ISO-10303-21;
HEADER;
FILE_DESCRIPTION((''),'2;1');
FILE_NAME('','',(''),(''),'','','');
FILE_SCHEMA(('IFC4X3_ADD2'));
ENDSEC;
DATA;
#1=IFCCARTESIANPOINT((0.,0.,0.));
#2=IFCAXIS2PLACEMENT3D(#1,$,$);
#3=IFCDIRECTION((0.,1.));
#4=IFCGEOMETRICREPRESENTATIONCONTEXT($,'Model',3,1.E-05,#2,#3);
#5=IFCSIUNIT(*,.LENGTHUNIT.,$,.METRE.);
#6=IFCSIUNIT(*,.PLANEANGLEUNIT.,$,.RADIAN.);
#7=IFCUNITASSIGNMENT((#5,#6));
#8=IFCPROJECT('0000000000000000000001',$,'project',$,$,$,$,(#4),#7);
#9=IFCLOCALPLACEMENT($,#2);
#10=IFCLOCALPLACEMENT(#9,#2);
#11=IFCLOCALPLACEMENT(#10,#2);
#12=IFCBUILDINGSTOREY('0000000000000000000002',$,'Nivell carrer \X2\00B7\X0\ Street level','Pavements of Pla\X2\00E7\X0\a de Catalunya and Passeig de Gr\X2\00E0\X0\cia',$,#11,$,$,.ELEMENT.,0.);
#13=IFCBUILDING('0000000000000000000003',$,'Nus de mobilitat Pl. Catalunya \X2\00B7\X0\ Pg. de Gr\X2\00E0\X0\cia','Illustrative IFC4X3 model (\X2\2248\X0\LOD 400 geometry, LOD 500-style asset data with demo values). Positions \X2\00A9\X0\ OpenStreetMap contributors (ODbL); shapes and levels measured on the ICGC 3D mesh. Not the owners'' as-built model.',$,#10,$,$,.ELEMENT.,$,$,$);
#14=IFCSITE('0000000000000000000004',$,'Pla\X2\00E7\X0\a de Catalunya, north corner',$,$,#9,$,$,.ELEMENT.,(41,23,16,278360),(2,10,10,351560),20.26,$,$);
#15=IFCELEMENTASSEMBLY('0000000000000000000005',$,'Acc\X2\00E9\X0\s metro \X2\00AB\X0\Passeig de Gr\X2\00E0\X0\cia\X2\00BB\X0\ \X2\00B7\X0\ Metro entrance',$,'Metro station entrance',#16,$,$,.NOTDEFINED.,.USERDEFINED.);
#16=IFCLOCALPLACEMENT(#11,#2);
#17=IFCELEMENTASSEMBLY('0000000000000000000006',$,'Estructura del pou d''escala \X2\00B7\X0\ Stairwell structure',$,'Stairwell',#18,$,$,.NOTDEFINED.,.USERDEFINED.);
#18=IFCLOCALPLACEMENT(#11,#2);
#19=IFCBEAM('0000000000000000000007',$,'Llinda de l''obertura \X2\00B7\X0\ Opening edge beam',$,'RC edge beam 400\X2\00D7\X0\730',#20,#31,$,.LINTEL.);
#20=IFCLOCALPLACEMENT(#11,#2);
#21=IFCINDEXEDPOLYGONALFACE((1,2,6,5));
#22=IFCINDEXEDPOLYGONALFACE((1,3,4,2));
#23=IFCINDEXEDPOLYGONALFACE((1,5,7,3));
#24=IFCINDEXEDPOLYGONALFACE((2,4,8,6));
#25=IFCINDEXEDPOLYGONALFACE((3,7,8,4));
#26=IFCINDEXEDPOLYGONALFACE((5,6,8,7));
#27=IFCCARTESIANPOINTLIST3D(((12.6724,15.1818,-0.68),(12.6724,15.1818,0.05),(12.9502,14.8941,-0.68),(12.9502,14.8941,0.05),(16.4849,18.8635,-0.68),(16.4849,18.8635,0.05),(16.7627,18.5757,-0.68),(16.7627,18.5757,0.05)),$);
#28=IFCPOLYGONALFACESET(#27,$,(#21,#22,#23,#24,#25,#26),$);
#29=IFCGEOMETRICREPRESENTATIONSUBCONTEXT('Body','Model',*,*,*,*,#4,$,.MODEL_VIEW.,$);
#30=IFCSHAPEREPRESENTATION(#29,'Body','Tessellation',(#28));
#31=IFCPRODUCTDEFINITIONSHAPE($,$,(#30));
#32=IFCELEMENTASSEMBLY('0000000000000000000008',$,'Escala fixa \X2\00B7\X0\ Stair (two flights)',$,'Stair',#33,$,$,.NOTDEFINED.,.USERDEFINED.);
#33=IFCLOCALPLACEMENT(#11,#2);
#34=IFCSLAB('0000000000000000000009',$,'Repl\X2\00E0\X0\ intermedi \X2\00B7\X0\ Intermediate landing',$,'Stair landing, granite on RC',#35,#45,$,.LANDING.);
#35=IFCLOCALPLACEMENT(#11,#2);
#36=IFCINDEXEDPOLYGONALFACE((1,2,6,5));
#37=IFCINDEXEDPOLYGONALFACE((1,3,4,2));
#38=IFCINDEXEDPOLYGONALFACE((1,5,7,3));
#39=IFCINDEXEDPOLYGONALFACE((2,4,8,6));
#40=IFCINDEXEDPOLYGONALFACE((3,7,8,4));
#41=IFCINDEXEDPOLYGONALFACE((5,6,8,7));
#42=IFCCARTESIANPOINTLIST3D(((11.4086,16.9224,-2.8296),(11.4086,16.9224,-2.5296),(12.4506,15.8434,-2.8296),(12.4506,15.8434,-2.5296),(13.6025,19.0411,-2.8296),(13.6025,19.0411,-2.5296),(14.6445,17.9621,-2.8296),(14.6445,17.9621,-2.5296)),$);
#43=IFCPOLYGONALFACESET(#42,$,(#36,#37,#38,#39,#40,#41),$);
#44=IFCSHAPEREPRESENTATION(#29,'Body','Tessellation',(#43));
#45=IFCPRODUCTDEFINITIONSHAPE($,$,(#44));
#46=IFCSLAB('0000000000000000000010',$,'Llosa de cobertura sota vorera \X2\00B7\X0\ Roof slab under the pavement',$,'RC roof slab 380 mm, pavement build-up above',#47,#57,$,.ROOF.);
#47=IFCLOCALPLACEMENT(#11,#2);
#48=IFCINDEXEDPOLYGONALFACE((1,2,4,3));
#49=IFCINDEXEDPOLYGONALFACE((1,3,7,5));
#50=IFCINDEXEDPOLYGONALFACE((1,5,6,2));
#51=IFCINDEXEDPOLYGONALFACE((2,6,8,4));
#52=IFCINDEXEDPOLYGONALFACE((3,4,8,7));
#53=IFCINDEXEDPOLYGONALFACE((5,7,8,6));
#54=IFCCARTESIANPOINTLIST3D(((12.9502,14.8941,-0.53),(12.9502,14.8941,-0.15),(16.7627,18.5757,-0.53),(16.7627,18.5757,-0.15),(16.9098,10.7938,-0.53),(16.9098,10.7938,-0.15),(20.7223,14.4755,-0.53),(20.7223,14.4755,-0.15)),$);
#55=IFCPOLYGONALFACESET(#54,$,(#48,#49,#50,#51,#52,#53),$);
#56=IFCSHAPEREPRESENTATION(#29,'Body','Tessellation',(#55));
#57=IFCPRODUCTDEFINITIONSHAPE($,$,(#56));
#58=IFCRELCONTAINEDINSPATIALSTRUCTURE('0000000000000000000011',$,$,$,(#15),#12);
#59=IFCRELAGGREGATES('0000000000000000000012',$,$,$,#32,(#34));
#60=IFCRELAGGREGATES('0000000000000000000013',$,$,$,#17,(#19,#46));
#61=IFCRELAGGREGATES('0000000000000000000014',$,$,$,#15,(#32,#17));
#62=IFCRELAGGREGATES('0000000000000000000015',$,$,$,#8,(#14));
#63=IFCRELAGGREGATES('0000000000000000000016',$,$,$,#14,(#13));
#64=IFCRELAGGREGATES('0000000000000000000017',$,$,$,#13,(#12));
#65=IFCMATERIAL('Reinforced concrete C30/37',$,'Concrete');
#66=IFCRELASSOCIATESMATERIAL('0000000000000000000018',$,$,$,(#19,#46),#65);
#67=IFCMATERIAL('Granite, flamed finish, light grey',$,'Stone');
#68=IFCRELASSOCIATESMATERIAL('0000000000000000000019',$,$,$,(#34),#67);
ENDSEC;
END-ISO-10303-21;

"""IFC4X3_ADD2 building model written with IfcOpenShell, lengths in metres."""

from ifc_helpers import new_model, si_unit, direction, frame, frame_2d, origin, place, context, subcontext, project, spatial, rectangle, extrude, material, element, aggregate, save


model = new_model("IFC4X3_ADD2")

# Units and contexts
model_context = context("Model", 3, precision=1e-05, world=origin(), true_north=direction((0.0, 1.0)))
body_context = subcontext(model_context, "Body", "Model", "MODEL_VIEW")
ifc_project = project(units=[si_unit("LENGTHUNIT", "METRE"), si_unit("PLANEANGLEUNIT", "RADIAN")], contexts=[model_context])

# Site, building, storey
site_placement = place(None, origin())
site = spatial("IfcSite", under=ifc_project, at=site_placement, Name="Plaça de Catalunya, north corner", CompositionType="ELEMENT", RefLatitude=(41, 23, 16, 278360), RefLongitude=(2, 10, 10, 351560), RefElevation=20.26)
building_placement = place(site_placement, origin())
building = spatial("IfcBuilding", under=site, at=building_placement, Name="Nus de mobilitat Pl. Catalunya · Pg. de Gràcia", Description="Illustrative IFC4X3 model (≈LOD 400 geometry, LOD 500-style asset data with demo values). Positions © OpenStreetMap contributors (ODbL); shapes and levels measured on the ICGC 3D mesh. Not the owners' as-built model.", CompositionType="ELEMENT")
storey_placement = place(building_placement, origin())
storey = spatial("IfcBuildingStorey", under=building, at=storey_placement, Name="Nivell carrer · Street level", Description="Pavements of Plaça de Catalunya and Passeig de Gràcia", CompositionType="ELEMENT", Elevation=0.0)

# Element assemblies, beam, slabs
assembly_1_placement = place(building_placement, origin())
assembly_1 = element("IfcElementAssembly", 1, at=assembly_1_placement, inside=storey, Name="Accés metro «Passeig de Gràcia» · Metro entrance", ObjectType="Metro station entrance", AssemblyPlace="NOTDEFINED", PredefinedType="USERDEFINED")
assembly_2_placement = place(building_placement, origin())
assembly_2 = element("IfcElementAssembly", 2, at=assembly_2_placement, Name="Estructura del pou d'escala · Stairwell structure", ObjectType="Stairwell", AssemblyPlace="NOTDEFINED", PredefinedType="USERDEFINED")
ifc_material_1 = material(Name="Reinforced concrete C30/37", Category="Concrete")
beam_placement = place(building_placement, origin())
beam = element("IfcBeam", 3, at=beam_placement, material=ifc_material_1, Name="Llinda de l'obertura · Opening edge beam", ObjectType="RC edge beam 400×730", PredefinedType="LINTEL", context=body_context, shape_type="SweptSolid", body=[
    extrude(rectangle(XDim=0.4, YDim=5.3, at=frame_2d((0.0, 0.0), x_axis=(0.694658, -0.71934))), frame((14.7176, 16.8788, -0.68)), (0.0, 0.0, 1.0), 0.73),
])
assembly_3_placement = place(building_placement, origin())
assembly_3 = element("IfcElementAssembly", 4, at=assembly_3_placement, Name="Escala fixa · Stair (two flights)", ObjectType="Stair", AssemblyPlace="NOTDEFINED", PredefinedType="USERDEFINED")
ifc_material_2 = material(Name="Granite, flamed finish, light grey", Category="Stone")
slab_1_placement = place(building_placement, origin())
slab_1 = element("IfcSlab", 5, at=slab_1_placement, material=ifc_material_2, Name="Replà intermedi · Intermediate landing", ObjectType="Stair landing, granite on RC", PredefinedType="LANDING", context=body_context, shape_type="SweptSolid", body=[
    extrude(rectangle(XDim=1.5, YDim=3.05, at=frame_2d((0.0, 0.0), x_axis=(0.694658, -0.71934))), frame((13.0265, 17.4422, -2.8296)), (0.0, 0.0, 1.0), 0.3),
])
slab_2_placement = place(building_placement, origin())
slab_2 = element("IfcSlab", 6, at=slab_2_placement, material=ifc_material_1, Name="Llosa de cobertura sota vorera · Roof slab under the pavement", ObjectType="RC roof slab 380 mm, pavement build-up above", PredefinedType="ROOF", context=body_context, shape_type="SweptSolid", body=[
    extrude(rectangle(XDim=5.7, YDim=5.3, at=frame_2d((0.0, 0.0), x_axis=(0.694658, -0.71934))), frame((16.8363, 14.6848, -0.53)), (0.0, 0.0, 1.0), 0.38),
])
aggregate(assembly_3, [slab_1])
aggregate(assembly_2, [beam, slab_2])
aggregate(assembly_1, [assembly_3, assembly_2])

save(model, "model.ifc")
